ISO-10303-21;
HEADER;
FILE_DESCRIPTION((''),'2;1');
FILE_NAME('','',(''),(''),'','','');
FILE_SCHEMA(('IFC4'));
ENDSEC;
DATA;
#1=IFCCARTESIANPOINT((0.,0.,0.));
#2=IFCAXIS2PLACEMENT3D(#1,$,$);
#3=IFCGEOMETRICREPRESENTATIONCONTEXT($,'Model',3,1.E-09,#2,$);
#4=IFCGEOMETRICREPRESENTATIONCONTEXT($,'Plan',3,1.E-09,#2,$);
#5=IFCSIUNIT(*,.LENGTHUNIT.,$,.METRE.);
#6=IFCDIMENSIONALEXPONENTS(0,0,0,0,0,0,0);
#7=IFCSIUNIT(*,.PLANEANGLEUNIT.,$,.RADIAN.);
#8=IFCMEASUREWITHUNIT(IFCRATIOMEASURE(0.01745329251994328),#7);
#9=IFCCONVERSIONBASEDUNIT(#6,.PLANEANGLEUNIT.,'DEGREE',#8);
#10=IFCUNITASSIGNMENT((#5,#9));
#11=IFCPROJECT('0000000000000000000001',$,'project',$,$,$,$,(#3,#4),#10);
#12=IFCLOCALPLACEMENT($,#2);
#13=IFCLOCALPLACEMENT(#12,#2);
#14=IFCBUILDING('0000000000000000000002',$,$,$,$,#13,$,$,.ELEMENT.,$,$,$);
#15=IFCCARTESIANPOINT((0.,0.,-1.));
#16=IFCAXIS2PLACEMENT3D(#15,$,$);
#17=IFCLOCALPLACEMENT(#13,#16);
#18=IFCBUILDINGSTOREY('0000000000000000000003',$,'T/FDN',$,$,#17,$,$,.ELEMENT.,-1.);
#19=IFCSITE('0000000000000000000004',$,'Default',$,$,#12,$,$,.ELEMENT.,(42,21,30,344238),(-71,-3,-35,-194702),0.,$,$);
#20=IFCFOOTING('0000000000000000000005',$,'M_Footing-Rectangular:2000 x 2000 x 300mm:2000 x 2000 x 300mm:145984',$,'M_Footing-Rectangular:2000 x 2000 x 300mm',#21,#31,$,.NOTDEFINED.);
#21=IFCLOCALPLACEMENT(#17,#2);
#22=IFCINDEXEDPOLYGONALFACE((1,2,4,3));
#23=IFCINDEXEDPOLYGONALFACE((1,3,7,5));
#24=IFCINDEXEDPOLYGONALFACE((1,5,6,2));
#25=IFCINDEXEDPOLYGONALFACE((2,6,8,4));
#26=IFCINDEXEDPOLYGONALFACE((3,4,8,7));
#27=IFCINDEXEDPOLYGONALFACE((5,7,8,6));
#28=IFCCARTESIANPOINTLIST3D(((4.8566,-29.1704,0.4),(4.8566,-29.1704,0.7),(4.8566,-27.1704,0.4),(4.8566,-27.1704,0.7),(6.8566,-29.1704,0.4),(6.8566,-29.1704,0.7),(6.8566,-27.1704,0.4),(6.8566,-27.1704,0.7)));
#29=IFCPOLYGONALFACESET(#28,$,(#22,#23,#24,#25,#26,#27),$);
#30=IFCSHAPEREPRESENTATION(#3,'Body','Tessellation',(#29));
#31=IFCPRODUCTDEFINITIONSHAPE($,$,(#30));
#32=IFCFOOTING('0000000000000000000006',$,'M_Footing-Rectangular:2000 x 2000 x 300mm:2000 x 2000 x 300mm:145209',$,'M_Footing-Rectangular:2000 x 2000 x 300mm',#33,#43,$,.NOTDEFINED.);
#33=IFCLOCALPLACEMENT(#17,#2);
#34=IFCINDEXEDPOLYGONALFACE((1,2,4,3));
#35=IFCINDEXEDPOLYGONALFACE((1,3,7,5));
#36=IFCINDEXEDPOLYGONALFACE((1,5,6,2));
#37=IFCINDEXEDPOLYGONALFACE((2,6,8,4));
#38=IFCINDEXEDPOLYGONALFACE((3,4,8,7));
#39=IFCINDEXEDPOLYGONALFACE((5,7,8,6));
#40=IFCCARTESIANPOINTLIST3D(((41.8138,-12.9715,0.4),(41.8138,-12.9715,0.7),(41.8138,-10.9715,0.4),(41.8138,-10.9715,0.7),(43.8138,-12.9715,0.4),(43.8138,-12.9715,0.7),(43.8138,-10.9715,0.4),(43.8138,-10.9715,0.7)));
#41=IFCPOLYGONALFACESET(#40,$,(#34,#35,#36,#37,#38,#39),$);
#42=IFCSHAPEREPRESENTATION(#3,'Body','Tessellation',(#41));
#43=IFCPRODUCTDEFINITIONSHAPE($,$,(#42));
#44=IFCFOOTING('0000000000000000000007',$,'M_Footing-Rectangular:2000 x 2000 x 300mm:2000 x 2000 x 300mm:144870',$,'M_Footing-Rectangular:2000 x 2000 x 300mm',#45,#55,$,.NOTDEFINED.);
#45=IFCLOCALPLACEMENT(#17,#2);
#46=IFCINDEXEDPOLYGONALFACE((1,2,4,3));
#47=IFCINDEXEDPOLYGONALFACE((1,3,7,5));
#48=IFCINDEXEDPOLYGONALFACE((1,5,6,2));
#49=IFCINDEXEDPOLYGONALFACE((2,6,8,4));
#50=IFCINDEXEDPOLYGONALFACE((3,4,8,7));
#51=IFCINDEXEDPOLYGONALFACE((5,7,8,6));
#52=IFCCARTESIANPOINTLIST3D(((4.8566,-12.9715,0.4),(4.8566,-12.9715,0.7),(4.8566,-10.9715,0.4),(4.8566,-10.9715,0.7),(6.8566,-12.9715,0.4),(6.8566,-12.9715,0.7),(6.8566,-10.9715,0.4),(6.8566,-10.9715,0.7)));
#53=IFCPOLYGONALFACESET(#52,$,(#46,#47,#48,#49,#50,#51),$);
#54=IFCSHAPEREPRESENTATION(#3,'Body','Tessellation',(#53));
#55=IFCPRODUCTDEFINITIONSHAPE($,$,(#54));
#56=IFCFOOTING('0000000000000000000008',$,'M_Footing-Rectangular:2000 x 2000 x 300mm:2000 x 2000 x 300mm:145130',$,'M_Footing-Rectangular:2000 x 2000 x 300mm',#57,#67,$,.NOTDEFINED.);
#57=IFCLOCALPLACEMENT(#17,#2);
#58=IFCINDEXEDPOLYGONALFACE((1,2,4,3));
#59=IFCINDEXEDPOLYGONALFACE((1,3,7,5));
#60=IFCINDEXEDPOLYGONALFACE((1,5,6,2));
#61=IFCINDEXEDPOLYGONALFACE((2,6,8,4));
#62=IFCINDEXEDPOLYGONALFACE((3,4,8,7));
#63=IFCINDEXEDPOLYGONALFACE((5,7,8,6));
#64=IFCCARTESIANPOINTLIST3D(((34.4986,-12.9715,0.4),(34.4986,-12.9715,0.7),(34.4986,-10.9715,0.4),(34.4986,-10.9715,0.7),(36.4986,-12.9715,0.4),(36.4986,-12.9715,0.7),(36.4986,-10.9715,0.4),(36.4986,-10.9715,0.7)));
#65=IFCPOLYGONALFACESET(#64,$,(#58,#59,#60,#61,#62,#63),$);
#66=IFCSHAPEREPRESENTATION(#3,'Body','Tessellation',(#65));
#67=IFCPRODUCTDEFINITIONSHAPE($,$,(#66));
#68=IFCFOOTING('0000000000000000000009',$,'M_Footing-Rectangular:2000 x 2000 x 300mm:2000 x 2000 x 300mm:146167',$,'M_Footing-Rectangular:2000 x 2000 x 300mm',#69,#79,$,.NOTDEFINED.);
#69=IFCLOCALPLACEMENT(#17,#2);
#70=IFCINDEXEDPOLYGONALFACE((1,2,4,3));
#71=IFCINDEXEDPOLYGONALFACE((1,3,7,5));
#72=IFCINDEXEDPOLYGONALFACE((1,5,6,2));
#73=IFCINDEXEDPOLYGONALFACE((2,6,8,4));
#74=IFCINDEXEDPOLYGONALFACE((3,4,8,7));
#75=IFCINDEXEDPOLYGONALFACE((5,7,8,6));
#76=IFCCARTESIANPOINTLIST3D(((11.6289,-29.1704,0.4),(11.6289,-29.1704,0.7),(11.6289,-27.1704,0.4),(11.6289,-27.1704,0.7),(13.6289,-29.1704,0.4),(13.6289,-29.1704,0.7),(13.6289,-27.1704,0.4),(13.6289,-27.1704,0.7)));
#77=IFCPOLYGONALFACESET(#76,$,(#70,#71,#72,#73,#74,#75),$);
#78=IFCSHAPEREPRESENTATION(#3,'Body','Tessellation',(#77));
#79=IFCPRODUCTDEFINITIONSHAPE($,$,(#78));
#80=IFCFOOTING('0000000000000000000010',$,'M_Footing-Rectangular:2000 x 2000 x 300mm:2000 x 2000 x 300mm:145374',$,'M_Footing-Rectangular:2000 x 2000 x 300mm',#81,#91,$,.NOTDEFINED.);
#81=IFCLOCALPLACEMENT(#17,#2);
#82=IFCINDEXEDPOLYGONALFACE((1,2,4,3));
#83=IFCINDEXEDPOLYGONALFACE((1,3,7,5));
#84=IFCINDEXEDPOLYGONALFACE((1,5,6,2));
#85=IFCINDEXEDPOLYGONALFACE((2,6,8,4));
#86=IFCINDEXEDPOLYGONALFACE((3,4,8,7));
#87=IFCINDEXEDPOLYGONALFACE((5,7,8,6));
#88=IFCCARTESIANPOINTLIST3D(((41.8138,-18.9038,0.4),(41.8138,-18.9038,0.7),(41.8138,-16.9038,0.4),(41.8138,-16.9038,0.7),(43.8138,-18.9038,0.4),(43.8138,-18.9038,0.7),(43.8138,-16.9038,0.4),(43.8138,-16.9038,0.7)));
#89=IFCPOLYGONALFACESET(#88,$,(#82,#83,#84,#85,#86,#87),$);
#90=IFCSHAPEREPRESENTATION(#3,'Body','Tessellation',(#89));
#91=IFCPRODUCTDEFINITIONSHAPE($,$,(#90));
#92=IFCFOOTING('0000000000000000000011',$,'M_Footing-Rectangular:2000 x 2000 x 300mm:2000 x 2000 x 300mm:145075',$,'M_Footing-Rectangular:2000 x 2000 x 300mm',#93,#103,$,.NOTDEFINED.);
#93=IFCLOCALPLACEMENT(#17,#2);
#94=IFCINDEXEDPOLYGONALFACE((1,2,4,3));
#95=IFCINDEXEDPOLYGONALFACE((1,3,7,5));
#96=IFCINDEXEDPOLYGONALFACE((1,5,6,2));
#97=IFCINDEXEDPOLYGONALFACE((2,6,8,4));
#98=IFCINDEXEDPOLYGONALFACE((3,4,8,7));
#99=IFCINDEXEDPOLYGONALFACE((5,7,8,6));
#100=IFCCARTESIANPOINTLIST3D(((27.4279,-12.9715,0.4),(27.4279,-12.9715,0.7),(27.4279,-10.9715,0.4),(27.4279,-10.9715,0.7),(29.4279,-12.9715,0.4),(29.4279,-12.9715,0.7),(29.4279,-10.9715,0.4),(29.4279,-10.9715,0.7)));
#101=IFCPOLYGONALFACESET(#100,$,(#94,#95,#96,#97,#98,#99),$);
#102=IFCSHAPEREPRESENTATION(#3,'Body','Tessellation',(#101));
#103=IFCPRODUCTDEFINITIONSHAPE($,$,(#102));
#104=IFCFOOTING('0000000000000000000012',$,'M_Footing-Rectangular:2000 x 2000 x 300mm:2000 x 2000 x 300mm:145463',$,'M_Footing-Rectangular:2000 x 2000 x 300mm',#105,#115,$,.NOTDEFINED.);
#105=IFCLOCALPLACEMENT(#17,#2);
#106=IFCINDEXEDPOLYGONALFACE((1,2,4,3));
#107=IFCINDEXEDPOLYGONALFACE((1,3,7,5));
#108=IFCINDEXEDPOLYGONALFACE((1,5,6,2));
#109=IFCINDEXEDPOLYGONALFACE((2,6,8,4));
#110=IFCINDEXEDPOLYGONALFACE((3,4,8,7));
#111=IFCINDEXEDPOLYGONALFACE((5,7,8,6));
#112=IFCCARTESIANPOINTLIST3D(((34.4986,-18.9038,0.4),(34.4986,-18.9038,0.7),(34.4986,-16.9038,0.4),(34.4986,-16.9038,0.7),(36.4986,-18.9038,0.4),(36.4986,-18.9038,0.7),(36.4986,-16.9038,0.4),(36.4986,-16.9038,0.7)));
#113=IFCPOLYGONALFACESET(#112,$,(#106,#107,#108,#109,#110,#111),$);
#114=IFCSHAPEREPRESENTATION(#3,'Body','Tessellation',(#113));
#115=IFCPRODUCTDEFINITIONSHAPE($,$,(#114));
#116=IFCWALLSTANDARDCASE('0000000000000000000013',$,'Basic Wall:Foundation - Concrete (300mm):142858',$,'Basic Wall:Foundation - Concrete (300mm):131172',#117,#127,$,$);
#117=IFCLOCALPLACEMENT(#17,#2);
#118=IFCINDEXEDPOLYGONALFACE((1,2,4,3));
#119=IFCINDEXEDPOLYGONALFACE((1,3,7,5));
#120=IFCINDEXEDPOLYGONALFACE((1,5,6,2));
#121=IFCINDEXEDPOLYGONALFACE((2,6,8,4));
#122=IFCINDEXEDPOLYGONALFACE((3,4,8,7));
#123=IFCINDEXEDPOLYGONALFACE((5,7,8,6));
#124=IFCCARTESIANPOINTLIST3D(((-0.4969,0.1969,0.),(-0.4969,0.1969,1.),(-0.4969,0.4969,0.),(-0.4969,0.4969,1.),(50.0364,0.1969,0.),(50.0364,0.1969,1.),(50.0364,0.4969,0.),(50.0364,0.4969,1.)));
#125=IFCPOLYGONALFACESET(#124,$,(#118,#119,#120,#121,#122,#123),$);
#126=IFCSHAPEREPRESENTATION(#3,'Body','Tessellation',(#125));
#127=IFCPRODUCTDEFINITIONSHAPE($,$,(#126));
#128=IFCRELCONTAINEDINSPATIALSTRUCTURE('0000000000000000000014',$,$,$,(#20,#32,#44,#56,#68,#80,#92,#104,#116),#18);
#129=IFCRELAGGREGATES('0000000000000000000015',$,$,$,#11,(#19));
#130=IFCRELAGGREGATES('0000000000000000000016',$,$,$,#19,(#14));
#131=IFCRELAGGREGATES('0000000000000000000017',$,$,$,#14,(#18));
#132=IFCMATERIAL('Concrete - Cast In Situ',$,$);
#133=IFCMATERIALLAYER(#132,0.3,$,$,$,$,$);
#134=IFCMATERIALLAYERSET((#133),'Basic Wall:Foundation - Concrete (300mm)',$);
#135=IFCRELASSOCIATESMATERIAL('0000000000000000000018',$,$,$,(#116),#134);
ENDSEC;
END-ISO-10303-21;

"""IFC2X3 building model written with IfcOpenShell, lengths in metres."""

from ifc_helpers import new_model, entity, si_unit, converted_unit, frame, frame_2d, origin, origin_2d_with_axis, place, context, project, spatial, rectangle, extrude, material, layer, layer_set, layer_usage, element, save


model = new_model("IFC2X3")

# Units and contexts
model_context = context("Model", 3, precision=1e-09, world=origin())
plan_context = context("Plan", 3, precision=1e-09, world=origin())
ifc_project = project(units=[si_unit("LENGTHUNIT", "METRE"), converted_unit("PLANEANGLEUNIT", "DEGREE", entity("IfcRatioMeasure", 0.01745329251994328), si_unit("PLANEANGLEUNIT", "RADIAN"), dimensions=[0, 0, 0, 0, 0, 0, 0])], contexts=[model_context, plan_context])

# Site, building, storey
site_placement = place(None, origin())
site = spatial("IfcSite", under=ifc_project, at=site_placement, Name="Default", CompositionType="ELEMENT", RefLatitude=(42, 21, 30, 344238), RefLongitude=(-71, -3, -35, -194702), RefElevation=0.0)
building_placement = place(site_placement, origin())
building = spatial("IfcBuilding", under=site, at=building_placement, CompositionType="ELEMENT")
storey_placement = place(building_placement, frame((0.0, 0.0, -1.0)))
storey = spatial("IfcBuildingStorey", under=building, at=storey_placement, Name="T/FDN", CompositionType="ELEMENT", Elevation=-1.0)

# Footings
footing_1_placement = place(storey_placement, origin())
element("IfcFooting", 1, at=footing_1_placement, inside=storey, Name="M_Footing-Rectangular:2000 x 2000 x 300mm:2000 x 2000 x 300mm:145984", ObjectType="M_Footing-Rectangular:2000 x 2000 x 300mm", PredefinedType="NOTDEFINED", context=model_context, shape_type="SweptSolid", body=[
    extrude(rectangle(XDim=2.0, YDim=2.0, at=origin_2d_with_axis()), frame((5.8566, -28.1704, 0.4), z_axis=(0.0, 0.0, 1.0), x_axis=(-1.0, 0.0, 0.0)), (0.0, 0.0, 1.0), 0.3),
])
footing_2_placement = place(storey_placement, origin())
element("IfcFooting", 2, at=footing_2_placement, inside=storey, Name="M_Footing-Rectangular:2000 x 2000 x 300mm:2000 x 2000 x 300mm:145209", ObjectType="M_Footing-Rectangular:2000 x 2000 x 300mm", PredefinedType="NOTDEFINED", context=model_context, shape_type="SweptSolid", body=[
    extrude(rectangle(XDim=2.0, YDim=2.0, at=origin_2d_with_axis()), frame((42.8138, -11.9715, 0.4), z_axis=(0.0, 0.0, 1.0), x_axis=(-1.0, 0.0, 0.0)), (0.0, 0.0, 1.0), 0.3),
])
footing_3_placement = place(storey_placement, origin())
element("IfcFooting", 3, at=footing_3_placement, inside=storey, Name="M_Footing-Rectangular:2000 x 2000 x 300mm:2000 x 2000 x 300mm:144870", ObjectType="M_Footing-Rectangular:2000 x 2000 x 300mm", PredefinedType="NOTDEFINED", context=model_context, shape_type="SweptSolid", body=[
    extrude(rectangle(XDim=2.0, YDim=2.0, at=origin_2d_with_axis()), frame((5.8566, -11.9715, 0.4), z_axis=(0.0, 0.0, 1.0), x_axis=(-1.0, 0.0, 0.0)), (0.0, 0.0, 1.0), 0.3),
])
footing_4_placement = place(storey_placement, origin())
element("IfcFooting", 4, at=footing_4_placement, inside=storey, Name="M_Footing-Rectangular:2000 x 2000 x 300mm:2000 x 2000 x 300mm:145130", ObjectType="M_Footing-Rectangular:2000 x 2000 x 300mm", PredefinedType="NOTDEFINED", context=model_context, shape_type="SweptSolid", body=[
    extrude(rectangle(XDim=2.0, YDim=2.0, at=origin_2d_with_axis()), frame((35.4986, -11.9715, 0.4), z_axis=(0.0, 0.0, 1.0), x_axis=(-1.0, 0.0, 0.0)), (0.0, 0.0, 1.0), 0.3),
])
footing_5_placement = place(storey_placement, origin())
element("IfcFooting", 5, at=footing_5_placement, inside=storey, Name="M_Footing-Rectangular:2000 x 2000 x 300mm:2000 x 2000 x 300mm:146167", ObjectType="M_Footing-Rectangular:2000 x 2000 x 300mm", PredefinedType="NOTDEFINED", context=model_context, shape_type="SweptSolid", body=[
    extrude(rectangle(XDim=2.0, YDim=2.0, at=origin_2d_with_axis()), frame((12.6289, -28.1704, 0.4), z_axis=(0.0, 0.0, 1.0), x_axis=(-1.0, 0.0, 0.0)), (0.0, 0.0, 1.0), 0.3),
])
footing_6_placement = place(storey_placement, origin())
element("IfcFooting", 6, at=footing_6_placement, inside=storey, Name="M_Footing-Rectangular:2000 x 2000 x 300mm:2000 x 2000 x 300mm:145374", ObjectType="M_Footing-Rectangular:2000 x 2000 x 300mm", PredefinedType="NOTDEFINED", context=model_context, shape_type="SweptSolid", body=[
    extrude(rectangle(XDim=2.0, YDim=2.0, at=origin_2d_with_axis()), frame((42.8138, -17.9038, 0.4), z_axis=(0.0, 0.0, 1.0), x_axis=(-1.0, 0.0, 0.0)), (0.0, 0.0, 1.0), 0.3),
])
footing_7_placement = place(storey_placement, origin())
element("IfcFooting", 7, at=footing_7_placement, inside=storey, Name="M_Footing-Rectangular:2000 x 2000 x 300mm:2000 x 2000 x 300mm:145075", ObjectType="M_Footing-Rectangular:2000 x 2000 x 300mm", PredefinedType="NOTDEFINED", context=model_context, shape_type="SweptSolid", body=[
    extrude(rectangle(XDim=2.0, YDim=2.0, at=origin_2d_with_axis()), frame((28.4279, -11.9715, 0.4), z_axis=(0.0, 0.0, 1.0), x_axis=(-1.0, 0.0, 0.0)), (0.0, 0.0, 1.0), 0.3),
])
footing_8_placement = place(storey_placement, origin())
element("IfcFooting", 8, at=footing_8_placement, inside=storey, Name="M_Footing-Rectangular:2000 x 2000 x 300mm:2000 x 2000 x 300mm:145463", ObjectType="M_Footing-Rectangular:2000 x 2000 x 300mm", PredefinedType="NOTDEFINED", context=model_context, shape_type="SweptSolid", body=[
    extrude(rectangle(XDim=2.0, YDim=2.0, at=origin_2d_with_axis()), frame((35.4986, -17.9038, 0.4), z_axis=(0.0, 0.0, 1.0), x_axis=(-1.0, 0.0, 0.0)), (0.0, 0.0, 1.0), 0.3),
])

# Wall
ifc_material = material(Name="Concrete - Cast In Situ")
ifc_layer = layer(ifc_material, 0.3)
ifc_layer_set = layer_set([ifc_layer], Name="Basic Wall:Foundation - Concrete (300mm)")
ifc_layer_usage = layer_usage(ifc_layer_set, "AXIS2", "NEGATIVE", 0.15)
wall_placement = place(storey_placement, frame((-0.4969, 0.3469, 0.0)))
element("IfcWallStandardCase", 9, at=wall_placement, inside=storey, material=ifc_layer_usage, Name="Basic Wall:Foundation - Concrete (300mm):142858", ObjectType="Basic Wall:Foundation - Concrete (300mm):131172", context=model_context, shape_type="SweptSolid", body=[
    extrude(rectangle(XDim=50.5333, YDim=0.3, at=frame_2d((25.2667, 0.0), x_axis=(-1.0, 0.0))), origin(), (0.0, 0.0, 1.0), 1.0),
])

save(model, "model.ifc")
